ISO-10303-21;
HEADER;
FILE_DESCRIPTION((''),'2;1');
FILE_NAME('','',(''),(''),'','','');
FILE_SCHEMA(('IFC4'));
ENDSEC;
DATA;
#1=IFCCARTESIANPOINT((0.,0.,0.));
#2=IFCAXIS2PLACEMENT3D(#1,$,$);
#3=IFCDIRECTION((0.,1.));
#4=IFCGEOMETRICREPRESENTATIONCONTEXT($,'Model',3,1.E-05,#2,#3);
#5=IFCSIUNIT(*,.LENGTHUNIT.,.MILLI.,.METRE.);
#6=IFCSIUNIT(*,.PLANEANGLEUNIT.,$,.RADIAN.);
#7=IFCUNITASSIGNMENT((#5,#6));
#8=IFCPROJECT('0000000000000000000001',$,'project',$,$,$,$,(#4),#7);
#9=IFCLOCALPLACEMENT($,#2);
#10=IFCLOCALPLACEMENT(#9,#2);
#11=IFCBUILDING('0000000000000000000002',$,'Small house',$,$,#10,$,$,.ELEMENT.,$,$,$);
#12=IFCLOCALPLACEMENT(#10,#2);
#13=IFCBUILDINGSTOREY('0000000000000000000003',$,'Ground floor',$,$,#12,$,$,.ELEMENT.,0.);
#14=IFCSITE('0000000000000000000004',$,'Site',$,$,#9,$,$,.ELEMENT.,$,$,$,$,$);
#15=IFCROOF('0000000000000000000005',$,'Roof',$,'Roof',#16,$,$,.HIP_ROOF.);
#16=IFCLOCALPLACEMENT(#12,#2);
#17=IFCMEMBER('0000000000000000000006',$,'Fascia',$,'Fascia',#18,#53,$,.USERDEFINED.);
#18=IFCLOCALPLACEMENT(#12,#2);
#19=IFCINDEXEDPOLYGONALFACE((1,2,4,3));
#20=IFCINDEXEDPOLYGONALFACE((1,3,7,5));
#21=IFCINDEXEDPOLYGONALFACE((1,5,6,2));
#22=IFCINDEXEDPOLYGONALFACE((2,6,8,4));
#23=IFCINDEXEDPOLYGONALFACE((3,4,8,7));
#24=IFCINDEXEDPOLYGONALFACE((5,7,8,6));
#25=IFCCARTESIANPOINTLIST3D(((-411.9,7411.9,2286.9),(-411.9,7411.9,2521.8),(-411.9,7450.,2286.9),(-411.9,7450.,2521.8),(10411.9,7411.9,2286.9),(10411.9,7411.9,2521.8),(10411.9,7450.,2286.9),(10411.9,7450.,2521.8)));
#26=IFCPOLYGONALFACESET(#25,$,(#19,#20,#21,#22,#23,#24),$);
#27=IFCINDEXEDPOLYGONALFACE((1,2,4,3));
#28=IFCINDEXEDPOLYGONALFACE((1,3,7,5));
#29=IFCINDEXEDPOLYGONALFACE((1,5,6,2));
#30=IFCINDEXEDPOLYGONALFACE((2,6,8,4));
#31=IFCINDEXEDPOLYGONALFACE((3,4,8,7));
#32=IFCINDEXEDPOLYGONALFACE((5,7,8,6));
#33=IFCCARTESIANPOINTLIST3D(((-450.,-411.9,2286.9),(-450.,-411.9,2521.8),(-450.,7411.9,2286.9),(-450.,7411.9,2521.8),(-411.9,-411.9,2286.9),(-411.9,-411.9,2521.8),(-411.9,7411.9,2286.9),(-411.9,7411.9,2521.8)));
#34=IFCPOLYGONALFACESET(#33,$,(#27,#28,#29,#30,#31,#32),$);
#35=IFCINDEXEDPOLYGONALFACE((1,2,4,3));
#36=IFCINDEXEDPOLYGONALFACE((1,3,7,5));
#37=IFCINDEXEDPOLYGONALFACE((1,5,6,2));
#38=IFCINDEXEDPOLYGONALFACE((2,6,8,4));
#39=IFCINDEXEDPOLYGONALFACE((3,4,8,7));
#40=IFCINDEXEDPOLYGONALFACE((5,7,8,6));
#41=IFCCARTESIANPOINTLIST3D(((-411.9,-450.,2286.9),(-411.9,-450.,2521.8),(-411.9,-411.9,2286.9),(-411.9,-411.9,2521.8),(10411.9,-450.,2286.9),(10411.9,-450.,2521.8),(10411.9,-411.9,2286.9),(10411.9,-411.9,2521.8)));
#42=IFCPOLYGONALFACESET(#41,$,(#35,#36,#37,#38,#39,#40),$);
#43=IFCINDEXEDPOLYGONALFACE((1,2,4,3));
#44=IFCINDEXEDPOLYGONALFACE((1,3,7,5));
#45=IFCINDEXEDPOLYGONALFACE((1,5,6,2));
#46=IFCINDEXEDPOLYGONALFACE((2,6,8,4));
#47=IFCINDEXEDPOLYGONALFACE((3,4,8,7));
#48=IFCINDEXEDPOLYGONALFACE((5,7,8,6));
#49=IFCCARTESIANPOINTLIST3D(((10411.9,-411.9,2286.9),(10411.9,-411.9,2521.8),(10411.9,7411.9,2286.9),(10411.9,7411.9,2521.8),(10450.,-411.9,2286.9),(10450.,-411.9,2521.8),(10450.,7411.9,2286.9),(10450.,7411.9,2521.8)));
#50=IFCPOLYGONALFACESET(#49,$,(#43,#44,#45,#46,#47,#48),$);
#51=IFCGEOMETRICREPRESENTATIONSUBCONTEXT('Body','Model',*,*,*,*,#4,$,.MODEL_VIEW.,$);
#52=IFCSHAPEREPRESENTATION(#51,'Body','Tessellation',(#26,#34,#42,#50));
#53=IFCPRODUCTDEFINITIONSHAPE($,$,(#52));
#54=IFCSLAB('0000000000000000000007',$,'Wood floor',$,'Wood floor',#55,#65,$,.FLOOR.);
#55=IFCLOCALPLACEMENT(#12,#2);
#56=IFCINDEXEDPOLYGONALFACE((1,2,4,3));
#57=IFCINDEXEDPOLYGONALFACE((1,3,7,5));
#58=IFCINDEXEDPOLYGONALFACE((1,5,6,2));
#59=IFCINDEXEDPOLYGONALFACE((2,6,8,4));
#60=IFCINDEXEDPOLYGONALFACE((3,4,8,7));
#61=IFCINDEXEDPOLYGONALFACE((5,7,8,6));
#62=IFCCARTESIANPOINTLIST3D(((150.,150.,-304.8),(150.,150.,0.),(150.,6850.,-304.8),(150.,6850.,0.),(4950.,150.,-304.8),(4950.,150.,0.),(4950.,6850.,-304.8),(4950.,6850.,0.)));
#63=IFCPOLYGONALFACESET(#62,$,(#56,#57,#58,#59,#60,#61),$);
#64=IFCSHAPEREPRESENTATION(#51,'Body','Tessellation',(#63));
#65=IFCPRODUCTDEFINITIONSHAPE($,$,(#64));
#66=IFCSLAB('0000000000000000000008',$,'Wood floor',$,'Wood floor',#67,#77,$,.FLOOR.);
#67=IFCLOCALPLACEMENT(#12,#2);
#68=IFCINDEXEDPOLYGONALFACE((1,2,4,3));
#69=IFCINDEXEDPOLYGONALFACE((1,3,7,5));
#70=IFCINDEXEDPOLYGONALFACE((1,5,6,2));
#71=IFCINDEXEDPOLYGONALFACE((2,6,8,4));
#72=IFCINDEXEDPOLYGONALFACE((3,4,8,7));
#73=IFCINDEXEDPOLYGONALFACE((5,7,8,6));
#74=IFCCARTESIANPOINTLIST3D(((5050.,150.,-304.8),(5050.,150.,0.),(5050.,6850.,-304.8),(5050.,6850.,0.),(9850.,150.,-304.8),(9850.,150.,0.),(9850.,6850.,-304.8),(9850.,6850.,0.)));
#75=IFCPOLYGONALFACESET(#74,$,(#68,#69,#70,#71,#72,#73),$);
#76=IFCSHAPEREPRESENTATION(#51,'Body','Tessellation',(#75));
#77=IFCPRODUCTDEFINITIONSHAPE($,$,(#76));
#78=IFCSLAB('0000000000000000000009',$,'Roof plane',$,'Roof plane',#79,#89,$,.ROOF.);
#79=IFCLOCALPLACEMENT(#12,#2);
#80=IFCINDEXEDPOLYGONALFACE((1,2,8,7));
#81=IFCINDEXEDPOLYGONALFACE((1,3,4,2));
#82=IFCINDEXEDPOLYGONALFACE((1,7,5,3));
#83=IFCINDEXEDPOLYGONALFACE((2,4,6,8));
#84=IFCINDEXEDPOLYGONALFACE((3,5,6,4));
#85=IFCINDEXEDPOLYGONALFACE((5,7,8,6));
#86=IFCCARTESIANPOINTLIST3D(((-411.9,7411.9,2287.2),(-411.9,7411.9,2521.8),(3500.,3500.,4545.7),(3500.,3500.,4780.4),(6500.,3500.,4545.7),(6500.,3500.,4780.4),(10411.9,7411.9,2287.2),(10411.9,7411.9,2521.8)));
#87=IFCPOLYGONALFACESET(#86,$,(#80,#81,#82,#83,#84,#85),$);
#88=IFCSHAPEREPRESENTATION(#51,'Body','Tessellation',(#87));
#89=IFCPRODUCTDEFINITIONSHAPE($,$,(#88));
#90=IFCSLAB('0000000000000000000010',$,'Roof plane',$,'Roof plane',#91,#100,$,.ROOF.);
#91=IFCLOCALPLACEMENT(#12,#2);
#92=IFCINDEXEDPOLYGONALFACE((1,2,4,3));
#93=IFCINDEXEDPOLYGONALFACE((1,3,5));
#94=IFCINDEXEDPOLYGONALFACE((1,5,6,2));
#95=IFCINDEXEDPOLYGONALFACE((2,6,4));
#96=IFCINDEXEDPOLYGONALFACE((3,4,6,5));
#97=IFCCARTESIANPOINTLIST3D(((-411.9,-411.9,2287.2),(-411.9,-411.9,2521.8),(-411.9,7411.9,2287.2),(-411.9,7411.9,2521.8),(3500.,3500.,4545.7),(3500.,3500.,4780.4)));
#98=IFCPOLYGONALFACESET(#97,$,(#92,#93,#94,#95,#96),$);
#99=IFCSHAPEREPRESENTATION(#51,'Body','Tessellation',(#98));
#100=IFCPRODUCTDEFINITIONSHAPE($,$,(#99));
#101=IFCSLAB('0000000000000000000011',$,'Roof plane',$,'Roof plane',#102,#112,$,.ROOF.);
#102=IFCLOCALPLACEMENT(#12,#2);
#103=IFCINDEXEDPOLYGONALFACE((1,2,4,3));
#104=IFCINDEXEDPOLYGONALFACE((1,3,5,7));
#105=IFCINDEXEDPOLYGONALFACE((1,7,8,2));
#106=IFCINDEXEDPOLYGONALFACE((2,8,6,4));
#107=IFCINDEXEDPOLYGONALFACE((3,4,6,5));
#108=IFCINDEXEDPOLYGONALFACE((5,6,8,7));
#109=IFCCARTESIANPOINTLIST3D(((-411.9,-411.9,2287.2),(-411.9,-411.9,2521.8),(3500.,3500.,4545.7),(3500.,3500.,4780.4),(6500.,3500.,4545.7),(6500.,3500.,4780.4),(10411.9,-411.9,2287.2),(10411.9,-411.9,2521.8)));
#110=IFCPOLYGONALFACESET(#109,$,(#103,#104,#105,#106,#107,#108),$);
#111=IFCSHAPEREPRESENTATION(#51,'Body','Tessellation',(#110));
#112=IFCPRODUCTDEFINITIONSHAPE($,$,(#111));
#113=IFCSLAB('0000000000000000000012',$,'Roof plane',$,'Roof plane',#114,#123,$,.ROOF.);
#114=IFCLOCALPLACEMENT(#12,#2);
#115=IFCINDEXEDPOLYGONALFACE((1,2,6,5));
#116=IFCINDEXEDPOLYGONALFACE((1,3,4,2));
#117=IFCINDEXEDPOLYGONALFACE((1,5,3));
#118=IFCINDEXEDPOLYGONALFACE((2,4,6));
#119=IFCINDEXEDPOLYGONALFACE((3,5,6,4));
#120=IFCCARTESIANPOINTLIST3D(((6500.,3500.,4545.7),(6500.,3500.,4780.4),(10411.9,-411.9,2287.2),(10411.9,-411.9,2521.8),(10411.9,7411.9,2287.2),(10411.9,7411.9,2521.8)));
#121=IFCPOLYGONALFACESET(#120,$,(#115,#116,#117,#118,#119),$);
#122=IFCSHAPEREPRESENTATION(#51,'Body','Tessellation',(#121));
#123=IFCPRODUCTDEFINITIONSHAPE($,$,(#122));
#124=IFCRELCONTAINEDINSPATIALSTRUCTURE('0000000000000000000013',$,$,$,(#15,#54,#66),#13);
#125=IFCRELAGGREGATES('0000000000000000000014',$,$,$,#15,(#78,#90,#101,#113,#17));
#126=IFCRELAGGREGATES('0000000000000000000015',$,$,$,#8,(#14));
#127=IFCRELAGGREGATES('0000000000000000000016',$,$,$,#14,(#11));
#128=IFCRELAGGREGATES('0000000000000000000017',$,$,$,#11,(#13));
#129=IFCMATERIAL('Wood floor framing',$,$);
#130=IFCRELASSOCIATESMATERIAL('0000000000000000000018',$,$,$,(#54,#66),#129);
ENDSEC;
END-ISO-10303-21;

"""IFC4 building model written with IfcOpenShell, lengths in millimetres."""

from ifc_helpers import new_model, si_unit, direction, frame, origin, origin_with_axes, place, context, subcontext, project, spatial, polyline, outline, extrude, material, element, aggregate, save


model = new_model("IFC4")

# Units and contexts
model_context = context("Model", 3, precision=1e-05, world=origin(), true_north=direction((0.0, 1.0)))
body_context = subcontext(model_context, "Body", "Model", "MODEL_VIEW")
ifc_project = project(units=[si_unit("LENGTHUNIT", "METRE", prefix="MILLI"), si_unit("PLANEANGLEUNIT", "RADIAN")], contexts=[model_context])

# Site, building, storey
site_placement = place(None, origin())
site = spatial("IfcSite", under=ifc_project, at=site_placement, Name="Site", CompositionType="ELEMENT")
building_placement = place(site_placement, origin())
building = spatial("IfcBuilding", under=site, at=building_placement, Name="Small house", CompositionType="ELEMENT")
storey_placement = place(building_placement, origin())
storey = spatial("IfcBuildingStorey", under=building, at=storey_placement, Name="Ground floor", CompositionType="ELEMENT", Elevation=0.0)

# Roof, member
roof_placement = place(storey_placement, origin_with_axes())
roof = element("IfcRoof", 1, at=roof_placement, inside=storey, Name="Roof", ObjectType="Roof", PredefinedType="HIP_ROOF")
member_placement = place(storey_placement, origin_with_axes())
member = element("IfcMember", 2, at=member_placement, Name="Fascia", ObjectType="Fascia", PredefinedType="USERDEFINED", context=body_context, shape_type="SweptSolid", body=[
    extrude(outline(polyline([(0.0, -234.9), (10823.8, -234.9), (10823.8, 0.0), (0.0, 0.0), (0.0, -234.9)])), frame((10411.9, 7411.9, 2521.8), z_axis=(0.0, 1.0, 0.0), x_axis=(-1.0, 0.0, 0.0)), (0.0, 0.0, 1.0), 38.1),
    extrude(outline(polyline([(0.0, -234.9), (7823.8, -234.9), (7823.8, 0.0), (0.0, 0.0), (0.0, -234.9)])), frame((-411.9, 7411.9, 2521.8), z_axis=(-1.0, 0.0, 0.0), x_axis=(0.0, -1.0, 0.0)), (0.0, 0.0, 1.0), 38.1),
    extrude(outline(polyline([(0.0, -234.9), (10823.8, -234.9), (10823.8, 0.0), (0.0, 0.0), (0.0, -234.9)])), frame((-411.9, -411.9, 2521.8), z_axis=(0.0, -1.0, 0.0), x_axis=(1.0, 0.0, 0.0)), (0.0, 0.0, 1.0), 38.1),
    extrude(outline(polyline([(0.0, -234.9), (7823.8, -234.9), (7823.8, 0.0), (0.0, 0.0), (0.0, -234.9)])), frame((10411.9, -411.9, 2521.8), z_axis=(1.0, 0.0, 0.0), x_axis=(0.0, 1.0, 0.0)), (0.0, 0.0, 1.0), 38.1),
])

# Slabs
ifc_material_1 = material(Name="Wood floor framing")
slab_1_placement = place(storey_placement, origin_with_axes())
element("IfcSlab", 3, at=slab_1_placement, inside=storey, material=ifc_material_1, Name="Wood floor", ObjectType="Wood floor", PredefinedType="FLOOR", context=body_context, shape_type="SweptSolid", body=[
    extrude(outline(polyline([(150.0, 150.0), (4950.0, 150.0), (4950.0, 6850.0), (150.0, 6850.0), (150.0, 150.0)])), frame((0.0, 0.0, -304.8)), (0.0, 0.0, 1.0), 304.8),
])
slab_2_placement = place(storey_placement, origin_with_axes())
element("IfcSlab", 4, at=slab_2_placement, inside=storey, material=ifc_material_1, Name="Wood floor", ObjectType="Wood floor", PredefinedType="FLOOR", context=body_context, shape_type="SweptSolid", body=[
    extrude(outline(polyline([(5050.0, 150.0), (9850.0, 150.0), (9850.0, 6850.0), (5050.0, 6850.0), (5050.0, 150.0)])), frame((0.0, 0.0, -304.8)), (0.0, 0.0, 1.0), 304.8),
])

# Slabs
slab_3_placement = place(storey_placement, origin_with_axes())
slab_3 = element("IfcSlab", 5, at=slab_3_placement, Name="Roof plane", ObjectType="Roof plane", PredefinedType="ROOF", context=body_context, shape_type="SweptSolid", body=[
    extrude(outline(polyline([(-10411.9, 0.0), (411.9, 0.0), (-3500.0, 4517.1), (-6500.0, 4517.1), (-10411.9, 0.0)])), frame((0.0, 7411.9, 2287.2), z_axis=(0.0, 0.5, 0.866025), x_axis=(-1.0, 0.0, 0.0)), (0.0, 0.5, 0.866025), 234.6),
])
slab_4_placement = place(storey_placement, origin_with_axes())
slab_4 = element("IfcSlab", 6, at=slab_4_placement, Name="Roof plane", ObjectType="Roof plane", PredefinedType="ROOF", context=body_context, shape_type="SweptSolid", body=[
    extrude(outline(polyline([(-7411.9, 0.0), (411.9, 0.0), (-3500.0, 4517.1), (-7411.9, 0.0)])), frame((-411.9, 0.0, 2287.2), z_axis=(-0.5, 0.0, 0.866025), x_axis=(0.0, -1.0, 0.0)), (0.0, 0.5, 0.866025), 234.6),
])
slab_5_placement = place(storey_placement, origin_with_axes())
slab_5 = element("IfcSlab", 7, at=slab_5_placement, Name="Roof plane", ObjectType="Roof plane", PredefinedType="ROOF", context=body_context, shape_type="SweptSolid", body=[
    extrude(outline(polyline([(-411.9, 0.0), (10411.9, 0.0), (6500.0, 4517.1), (3500.0, 4517.1), (-411.9, 0.0)])), frame((0.0, -411.9, 2287.2), z_axis=(0.0, -0.5, 0.866025), x_axis=(1.0, 0.0, 0.0)), (0.0, 0.5, 0.866025), 234.6),
])
slab_6_placement = place(storey_placement, origin_with_axes())
slab_6 = element("IfcSlab", 8, at=slab_6_placement, Name="Roof plane", ObjectType="Roof plane", PredefinedType="ROOF", context=body_context, shape_type="SweptSolid", body=[
    extrude(outline(polyline([(-411.9, 0.0), (7411.9, 0.0), (3500.0, 4517.1), (-411.9, 0.0)])), frame((10411.9, 0.0, 2287.2), z_axis=(0.5, 0.0, 0.866025), x_axis=(0.0, 1.0, 0.0)), (0.0, 0.5, 0.866025), 234.6),
])

aggregate(roof, [slab_3, slab_4, slab_5, slab_6, member])

save(model, "model.ifc")
